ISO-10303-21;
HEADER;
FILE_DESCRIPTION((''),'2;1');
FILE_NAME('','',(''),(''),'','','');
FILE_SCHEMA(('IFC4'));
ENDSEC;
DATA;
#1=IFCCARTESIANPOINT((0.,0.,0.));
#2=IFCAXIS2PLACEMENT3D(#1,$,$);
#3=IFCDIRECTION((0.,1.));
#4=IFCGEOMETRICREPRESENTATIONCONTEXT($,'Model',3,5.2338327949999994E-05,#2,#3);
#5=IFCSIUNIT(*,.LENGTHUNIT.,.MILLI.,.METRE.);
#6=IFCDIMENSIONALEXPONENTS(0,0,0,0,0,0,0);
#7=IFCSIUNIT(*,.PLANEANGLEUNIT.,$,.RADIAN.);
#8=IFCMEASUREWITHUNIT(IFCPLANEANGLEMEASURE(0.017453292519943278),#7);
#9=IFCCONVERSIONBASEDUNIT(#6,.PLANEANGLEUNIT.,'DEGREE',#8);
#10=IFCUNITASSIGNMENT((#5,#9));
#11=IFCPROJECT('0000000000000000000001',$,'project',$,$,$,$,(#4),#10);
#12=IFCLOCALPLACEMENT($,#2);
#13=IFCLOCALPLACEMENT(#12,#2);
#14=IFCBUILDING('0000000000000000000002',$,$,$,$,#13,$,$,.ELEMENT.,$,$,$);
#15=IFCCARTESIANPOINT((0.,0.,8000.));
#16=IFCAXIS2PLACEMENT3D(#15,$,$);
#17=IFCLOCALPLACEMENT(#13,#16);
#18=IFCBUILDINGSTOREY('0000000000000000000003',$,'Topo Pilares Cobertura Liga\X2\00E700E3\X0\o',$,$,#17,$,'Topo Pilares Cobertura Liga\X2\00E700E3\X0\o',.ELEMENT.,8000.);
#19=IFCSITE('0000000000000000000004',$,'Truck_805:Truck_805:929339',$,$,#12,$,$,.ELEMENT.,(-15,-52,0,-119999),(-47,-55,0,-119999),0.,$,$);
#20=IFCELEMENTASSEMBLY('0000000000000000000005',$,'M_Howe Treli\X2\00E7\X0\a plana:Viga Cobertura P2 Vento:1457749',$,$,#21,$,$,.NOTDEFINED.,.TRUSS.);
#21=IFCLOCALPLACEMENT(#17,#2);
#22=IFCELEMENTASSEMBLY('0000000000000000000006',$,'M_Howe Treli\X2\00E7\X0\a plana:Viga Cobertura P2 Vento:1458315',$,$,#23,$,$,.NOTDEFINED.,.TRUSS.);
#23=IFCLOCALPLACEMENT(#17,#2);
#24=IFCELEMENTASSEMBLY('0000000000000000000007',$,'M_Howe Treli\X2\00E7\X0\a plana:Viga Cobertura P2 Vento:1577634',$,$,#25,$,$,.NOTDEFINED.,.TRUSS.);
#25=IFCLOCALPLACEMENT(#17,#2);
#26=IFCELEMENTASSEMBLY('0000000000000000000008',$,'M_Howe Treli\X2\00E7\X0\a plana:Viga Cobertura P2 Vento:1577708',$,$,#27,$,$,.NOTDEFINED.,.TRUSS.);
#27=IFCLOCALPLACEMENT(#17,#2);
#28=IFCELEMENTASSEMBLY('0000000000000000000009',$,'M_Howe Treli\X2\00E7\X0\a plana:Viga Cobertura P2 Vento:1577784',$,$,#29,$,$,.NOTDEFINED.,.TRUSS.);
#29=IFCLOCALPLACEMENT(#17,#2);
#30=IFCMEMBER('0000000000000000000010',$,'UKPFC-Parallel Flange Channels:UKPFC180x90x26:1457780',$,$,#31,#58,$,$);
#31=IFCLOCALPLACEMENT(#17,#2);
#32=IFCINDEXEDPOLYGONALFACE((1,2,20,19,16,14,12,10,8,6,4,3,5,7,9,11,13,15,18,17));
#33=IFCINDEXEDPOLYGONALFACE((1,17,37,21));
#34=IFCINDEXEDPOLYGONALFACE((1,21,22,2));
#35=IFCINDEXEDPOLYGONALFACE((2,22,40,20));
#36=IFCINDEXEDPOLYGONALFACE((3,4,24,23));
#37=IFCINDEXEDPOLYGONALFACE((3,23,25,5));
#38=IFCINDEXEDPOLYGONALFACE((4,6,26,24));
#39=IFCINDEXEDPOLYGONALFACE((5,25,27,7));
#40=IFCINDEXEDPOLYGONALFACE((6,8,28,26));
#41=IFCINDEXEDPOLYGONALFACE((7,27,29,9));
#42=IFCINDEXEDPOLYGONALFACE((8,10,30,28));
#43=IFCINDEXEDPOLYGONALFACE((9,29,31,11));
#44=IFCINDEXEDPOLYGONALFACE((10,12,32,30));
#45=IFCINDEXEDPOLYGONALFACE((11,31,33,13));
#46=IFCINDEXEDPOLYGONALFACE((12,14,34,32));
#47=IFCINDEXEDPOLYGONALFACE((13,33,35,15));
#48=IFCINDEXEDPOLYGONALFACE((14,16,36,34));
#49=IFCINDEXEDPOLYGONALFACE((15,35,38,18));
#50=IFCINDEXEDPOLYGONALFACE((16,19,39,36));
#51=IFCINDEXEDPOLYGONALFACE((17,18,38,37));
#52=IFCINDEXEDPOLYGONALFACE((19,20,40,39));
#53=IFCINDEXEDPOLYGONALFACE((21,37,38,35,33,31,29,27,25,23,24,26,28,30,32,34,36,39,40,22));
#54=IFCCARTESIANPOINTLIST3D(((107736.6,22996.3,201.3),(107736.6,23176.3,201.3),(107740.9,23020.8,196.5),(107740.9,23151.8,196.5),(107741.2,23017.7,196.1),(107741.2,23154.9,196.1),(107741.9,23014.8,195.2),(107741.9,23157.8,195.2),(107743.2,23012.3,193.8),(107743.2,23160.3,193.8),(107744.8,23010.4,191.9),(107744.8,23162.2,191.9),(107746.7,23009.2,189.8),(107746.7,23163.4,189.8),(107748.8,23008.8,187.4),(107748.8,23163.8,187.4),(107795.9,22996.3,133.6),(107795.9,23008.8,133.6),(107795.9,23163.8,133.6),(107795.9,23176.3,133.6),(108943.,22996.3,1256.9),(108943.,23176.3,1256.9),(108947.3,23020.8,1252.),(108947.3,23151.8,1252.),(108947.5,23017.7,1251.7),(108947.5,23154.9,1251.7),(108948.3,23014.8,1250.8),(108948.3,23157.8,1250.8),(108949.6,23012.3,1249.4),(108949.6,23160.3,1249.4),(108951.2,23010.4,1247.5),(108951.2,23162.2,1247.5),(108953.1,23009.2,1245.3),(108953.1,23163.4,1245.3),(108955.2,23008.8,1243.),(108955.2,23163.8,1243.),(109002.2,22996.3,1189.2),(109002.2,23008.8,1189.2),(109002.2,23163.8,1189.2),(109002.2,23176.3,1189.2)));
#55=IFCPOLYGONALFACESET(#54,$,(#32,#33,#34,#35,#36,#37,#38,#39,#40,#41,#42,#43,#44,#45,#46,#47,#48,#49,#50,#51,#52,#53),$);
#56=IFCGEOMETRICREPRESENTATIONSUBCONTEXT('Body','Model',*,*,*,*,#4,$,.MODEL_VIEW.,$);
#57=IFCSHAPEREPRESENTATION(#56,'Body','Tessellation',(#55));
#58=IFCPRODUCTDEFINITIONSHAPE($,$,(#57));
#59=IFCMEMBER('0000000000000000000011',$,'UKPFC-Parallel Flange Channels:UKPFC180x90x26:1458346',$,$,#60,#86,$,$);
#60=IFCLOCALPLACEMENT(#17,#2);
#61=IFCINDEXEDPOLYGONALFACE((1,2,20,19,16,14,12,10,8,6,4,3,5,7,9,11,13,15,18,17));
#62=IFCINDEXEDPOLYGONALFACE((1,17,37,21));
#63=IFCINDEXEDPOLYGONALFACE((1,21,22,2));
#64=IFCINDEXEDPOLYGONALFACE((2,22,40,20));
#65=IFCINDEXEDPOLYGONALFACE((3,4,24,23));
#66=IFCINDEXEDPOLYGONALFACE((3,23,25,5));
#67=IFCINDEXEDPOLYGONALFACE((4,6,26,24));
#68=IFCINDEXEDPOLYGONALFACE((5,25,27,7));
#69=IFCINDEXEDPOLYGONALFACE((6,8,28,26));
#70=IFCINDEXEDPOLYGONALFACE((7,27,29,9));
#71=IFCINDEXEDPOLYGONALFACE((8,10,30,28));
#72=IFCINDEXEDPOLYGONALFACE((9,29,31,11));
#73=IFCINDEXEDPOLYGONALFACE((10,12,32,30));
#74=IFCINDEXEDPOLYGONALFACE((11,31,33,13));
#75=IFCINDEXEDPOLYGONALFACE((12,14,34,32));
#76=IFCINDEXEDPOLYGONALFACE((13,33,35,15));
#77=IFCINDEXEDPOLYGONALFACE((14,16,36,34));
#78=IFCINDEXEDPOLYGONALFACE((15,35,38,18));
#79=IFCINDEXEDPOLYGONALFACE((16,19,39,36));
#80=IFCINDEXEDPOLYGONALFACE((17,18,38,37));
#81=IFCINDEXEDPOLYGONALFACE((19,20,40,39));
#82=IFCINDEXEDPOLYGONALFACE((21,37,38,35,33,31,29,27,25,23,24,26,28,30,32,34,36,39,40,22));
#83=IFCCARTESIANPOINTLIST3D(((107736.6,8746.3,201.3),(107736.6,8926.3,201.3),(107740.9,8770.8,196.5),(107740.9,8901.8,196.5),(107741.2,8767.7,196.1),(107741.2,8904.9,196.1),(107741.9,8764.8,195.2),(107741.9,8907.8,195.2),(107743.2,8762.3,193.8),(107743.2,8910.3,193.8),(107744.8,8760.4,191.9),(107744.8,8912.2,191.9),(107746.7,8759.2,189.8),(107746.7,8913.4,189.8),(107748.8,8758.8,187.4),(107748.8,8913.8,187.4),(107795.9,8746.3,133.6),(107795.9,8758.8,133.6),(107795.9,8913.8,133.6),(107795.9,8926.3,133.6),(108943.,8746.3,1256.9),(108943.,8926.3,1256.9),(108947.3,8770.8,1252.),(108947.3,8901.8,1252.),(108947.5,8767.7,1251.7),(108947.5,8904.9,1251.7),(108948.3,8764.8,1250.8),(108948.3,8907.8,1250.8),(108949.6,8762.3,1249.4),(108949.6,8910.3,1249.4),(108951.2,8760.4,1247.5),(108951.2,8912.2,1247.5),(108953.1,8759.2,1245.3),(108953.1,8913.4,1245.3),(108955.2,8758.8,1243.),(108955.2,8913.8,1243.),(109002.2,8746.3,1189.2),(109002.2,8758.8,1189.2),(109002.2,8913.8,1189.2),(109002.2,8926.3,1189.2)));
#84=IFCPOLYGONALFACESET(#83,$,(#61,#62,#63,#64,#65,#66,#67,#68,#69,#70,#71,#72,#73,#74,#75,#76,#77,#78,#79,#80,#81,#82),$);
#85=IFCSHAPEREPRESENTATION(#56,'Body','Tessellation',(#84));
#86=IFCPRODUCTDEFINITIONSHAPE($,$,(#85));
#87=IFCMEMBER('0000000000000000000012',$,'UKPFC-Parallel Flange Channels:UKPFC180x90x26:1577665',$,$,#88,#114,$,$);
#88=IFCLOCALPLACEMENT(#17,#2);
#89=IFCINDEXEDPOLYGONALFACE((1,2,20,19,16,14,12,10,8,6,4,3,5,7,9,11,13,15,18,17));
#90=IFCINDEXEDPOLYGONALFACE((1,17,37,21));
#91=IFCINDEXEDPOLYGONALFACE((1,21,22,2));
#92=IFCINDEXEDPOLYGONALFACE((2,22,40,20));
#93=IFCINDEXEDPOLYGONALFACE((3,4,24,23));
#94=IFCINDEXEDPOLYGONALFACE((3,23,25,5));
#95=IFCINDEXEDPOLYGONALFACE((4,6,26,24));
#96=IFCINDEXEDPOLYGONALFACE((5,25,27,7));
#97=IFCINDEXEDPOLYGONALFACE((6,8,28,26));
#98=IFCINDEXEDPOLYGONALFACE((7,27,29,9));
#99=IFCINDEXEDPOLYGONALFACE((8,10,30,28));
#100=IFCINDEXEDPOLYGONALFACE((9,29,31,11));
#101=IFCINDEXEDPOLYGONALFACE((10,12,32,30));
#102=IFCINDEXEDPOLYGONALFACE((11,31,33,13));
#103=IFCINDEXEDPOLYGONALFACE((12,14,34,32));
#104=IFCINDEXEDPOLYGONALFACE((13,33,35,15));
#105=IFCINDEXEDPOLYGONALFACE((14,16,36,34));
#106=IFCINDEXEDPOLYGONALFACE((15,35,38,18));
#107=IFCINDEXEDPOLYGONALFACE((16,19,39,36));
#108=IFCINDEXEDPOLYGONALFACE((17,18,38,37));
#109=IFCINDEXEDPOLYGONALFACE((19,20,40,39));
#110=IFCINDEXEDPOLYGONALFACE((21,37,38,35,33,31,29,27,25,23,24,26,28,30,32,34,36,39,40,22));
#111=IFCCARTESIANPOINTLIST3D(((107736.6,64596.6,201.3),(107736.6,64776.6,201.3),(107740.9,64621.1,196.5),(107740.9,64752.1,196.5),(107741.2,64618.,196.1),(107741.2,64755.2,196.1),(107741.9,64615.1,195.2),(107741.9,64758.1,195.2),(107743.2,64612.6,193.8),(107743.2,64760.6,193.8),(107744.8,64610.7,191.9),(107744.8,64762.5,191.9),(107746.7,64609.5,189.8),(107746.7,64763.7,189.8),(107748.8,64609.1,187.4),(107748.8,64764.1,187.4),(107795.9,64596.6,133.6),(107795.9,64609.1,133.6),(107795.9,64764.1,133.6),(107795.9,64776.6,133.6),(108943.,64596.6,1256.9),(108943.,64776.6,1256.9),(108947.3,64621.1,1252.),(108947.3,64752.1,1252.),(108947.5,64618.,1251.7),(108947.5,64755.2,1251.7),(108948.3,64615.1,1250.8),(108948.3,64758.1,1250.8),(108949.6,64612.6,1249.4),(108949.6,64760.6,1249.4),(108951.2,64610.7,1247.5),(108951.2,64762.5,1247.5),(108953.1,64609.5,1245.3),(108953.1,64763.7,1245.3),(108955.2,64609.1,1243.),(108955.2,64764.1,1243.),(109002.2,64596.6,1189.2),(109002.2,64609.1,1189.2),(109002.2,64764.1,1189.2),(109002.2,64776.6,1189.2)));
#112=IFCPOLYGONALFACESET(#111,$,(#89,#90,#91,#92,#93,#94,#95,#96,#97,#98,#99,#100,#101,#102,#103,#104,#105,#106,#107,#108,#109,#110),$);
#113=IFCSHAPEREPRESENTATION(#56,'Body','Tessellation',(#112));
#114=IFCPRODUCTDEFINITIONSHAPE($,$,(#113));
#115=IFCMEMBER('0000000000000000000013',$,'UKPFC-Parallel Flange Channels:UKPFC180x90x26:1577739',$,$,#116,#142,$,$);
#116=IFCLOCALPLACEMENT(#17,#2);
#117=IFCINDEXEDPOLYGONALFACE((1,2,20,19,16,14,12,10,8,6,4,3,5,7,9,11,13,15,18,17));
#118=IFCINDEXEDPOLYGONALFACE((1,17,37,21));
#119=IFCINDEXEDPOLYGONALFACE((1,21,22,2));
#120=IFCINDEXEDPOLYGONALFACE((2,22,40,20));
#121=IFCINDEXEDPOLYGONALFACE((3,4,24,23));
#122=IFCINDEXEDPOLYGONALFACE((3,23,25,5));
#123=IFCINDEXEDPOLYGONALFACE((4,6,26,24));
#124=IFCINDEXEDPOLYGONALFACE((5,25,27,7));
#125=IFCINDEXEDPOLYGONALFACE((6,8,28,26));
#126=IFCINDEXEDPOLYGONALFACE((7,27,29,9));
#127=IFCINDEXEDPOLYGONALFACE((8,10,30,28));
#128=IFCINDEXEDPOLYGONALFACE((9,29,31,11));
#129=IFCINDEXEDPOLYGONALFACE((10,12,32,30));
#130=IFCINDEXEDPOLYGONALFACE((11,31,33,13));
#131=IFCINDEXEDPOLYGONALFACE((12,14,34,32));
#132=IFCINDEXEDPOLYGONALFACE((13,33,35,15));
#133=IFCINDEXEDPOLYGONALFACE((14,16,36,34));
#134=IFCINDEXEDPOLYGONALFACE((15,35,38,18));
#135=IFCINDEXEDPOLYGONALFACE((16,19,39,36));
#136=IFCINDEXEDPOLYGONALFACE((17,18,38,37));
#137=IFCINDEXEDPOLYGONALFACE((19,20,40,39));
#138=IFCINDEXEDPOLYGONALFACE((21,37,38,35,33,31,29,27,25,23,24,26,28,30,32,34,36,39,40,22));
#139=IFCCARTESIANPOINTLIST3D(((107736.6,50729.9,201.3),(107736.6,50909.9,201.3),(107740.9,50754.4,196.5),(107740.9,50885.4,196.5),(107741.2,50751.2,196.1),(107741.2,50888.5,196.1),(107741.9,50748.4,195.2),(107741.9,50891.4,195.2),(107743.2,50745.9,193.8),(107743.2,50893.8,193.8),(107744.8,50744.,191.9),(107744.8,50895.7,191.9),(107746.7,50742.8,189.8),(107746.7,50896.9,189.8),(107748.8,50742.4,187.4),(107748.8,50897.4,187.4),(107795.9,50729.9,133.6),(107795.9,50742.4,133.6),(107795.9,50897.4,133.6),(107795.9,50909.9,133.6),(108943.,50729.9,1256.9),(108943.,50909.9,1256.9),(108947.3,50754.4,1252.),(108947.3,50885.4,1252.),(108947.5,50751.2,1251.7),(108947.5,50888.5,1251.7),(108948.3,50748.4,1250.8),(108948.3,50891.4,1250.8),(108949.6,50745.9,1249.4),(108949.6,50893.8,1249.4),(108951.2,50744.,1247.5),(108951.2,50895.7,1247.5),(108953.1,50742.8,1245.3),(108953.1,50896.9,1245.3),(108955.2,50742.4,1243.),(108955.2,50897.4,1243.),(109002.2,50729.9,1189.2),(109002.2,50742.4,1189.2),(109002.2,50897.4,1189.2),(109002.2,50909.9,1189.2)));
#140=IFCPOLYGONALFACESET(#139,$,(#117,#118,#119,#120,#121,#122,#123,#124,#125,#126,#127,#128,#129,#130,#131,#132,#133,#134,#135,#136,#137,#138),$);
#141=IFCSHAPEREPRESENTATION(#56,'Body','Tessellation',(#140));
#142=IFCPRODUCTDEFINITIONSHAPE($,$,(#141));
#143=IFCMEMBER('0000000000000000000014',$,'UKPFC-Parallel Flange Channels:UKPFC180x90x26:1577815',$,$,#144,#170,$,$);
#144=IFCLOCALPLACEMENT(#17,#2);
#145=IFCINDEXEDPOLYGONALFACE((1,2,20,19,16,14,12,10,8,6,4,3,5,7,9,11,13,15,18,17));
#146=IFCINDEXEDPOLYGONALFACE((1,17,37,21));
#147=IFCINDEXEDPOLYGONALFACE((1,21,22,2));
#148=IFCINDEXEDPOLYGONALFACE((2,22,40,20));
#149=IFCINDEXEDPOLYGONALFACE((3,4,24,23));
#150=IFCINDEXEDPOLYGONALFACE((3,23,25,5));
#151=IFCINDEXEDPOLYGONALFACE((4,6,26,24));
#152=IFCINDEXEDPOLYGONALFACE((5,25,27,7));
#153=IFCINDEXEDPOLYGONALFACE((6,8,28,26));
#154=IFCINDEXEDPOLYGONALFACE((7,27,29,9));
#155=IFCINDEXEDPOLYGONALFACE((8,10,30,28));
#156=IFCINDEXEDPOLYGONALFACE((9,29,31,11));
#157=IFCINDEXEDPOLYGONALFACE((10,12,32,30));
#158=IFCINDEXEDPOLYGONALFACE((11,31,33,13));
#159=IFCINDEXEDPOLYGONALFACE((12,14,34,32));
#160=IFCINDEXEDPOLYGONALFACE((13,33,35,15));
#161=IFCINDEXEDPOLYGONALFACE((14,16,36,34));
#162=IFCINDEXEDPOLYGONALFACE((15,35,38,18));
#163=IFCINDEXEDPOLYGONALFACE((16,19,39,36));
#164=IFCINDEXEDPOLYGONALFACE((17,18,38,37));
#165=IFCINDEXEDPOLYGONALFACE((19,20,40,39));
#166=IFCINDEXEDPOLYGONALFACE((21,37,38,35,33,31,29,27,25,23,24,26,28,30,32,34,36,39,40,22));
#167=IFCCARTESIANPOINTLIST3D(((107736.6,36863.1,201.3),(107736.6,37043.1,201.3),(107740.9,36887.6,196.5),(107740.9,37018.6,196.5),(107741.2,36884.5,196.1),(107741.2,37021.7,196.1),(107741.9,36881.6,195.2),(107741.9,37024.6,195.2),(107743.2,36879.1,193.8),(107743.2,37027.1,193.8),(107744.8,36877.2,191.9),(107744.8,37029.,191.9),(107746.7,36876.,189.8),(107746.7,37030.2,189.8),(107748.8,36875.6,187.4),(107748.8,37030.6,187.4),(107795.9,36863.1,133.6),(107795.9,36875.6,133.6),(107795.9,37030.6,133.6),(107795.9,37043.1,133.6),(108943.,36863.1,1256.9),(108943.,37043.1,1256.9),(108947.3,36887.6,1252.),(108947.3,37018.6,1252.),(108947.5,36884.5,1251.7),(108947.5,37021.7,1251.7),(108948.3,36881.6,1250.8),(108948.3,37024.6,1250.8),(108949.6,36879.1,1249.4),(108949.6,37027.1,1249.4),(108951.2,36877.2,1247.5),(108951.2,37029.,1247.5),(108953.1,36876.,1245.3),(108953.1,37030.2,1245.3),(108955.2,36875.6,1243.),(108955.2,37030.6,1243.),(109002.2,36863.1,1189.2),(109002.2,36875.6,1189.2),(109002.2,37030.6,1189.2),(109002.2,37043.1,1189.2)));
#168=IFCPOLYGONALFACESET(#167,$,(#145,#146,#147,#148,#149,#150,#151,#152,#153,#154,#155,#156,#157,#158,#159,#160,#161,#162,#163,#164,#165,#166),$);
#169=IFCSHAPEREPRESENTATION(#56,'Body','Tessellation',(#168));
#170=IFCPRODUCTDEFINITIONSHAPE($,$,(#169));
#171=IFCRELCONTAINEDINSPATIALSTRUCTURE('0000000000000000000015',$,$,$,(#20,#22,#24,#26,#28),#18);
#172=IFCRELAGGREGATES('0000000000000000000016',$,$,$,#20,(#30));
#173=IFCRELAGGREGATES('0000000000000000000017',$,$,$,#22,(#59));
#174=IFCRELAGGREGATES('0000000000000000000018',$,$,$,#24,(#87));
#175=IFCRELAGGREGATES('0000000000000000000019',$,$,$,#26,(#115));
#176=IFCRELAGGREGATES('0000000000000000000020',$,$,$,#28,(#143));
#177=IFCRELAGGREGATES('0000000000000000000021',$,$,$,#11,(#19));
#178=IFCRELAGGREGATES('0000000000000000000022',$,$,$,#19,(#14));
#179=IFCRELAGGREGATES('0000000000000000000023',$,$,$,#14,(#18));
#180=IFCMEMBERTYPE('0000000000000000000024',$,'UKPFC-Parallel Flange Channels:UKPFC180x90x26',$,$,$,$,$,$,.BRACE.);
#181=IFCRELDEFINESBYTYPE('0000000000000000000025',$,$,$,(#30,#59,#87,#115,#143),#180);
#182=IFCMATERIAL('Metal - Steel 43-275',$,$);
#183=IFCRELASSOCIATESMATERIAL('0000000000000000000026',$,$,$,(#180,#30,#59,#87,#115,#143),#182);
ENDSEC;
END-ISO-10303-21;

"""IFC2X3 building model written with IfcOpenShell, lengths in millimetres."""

from ifc_helpers import new_model, entity, si_unit, converted_unit, direction, frame, frame_2d, origin, place, context, subcontext, project, spatial, polyline, circle_curve, parameter, trimmed, segment, composite_curve, outline, extrude, source, transform, mapped, material, type_object, type_shapes, element, aggregate, save


model = new_model("IFC2X3")

# Units and contexts
model_context = context("Model", 3, precision=5.2338327949999994e-05, world=origin(), true_north=direction((0.0, 1.0)))
body_context = subcontext(model_context, "Body", "Model", "MODEL_VIEW")
ifc_project = project(units=[si_unit("LENGTHUNIT", "METRE", prefix="MILLI"), converted_unit("PLANEANGLEUNIT", "DEGREE", entity("IfcPlaneAngleMeasure", 0.017453292519943278), si_unit("PLANEANGLEUNIT", "RADIAN"), dimensions=[0, 0, 0, 0, 0, 0, 0])], contexts=[model_context])

# Site, building, storey
site_placement = place(None, origin())
site = spatial("IfcSite", under=ifc_project, at=site_placement, Name="Truck_805:Truck_805:929339", CompositionType="ELEMENT", RefLatitude=(-15, -52, 0, -119999), RefLongitude=(-47, -55, 0, -119999), RefElevation=0.0)
building_placement = place(site_placement, origin())
building = spatial("IfcBuilding", under=site, at=building_placement, CompositionType="ELEMENT")
storey_placement = place(building_placement, frame((0.0, 0.0, 8000.0)))
storey = spatial("IfcBuildingStorey", under=building, at=storey_placement, Name="Topo Pilares Cobertura Ligação", LongName="Topo Pilares Cobertura Ligação", CompositionType="ELEMENT", Elevation=8000.0)

# Element assemblies
assembly_1_placement = place(storey_placement, origin())
assembly_1 = element("IfcElementAssembly", 1, at=assembly_1_placement, inside=storey, Name="M_Howe Treliça plana:Viga Cobertura P2 Vento:1457749", AssemblyPlace="NOTDEFINED", PredefinedType="TRUSS")
assembly_2_placement = place(storey_placement, origin())
assembly_2 = element("IfcElementAssembly", 2, at=assembly_2_placement, inside=storey, Name="M_Howe Treliça plana:Viga Cobertura P2 Vento:1458315", AssemblyPlace="NOTDEFINED", PredefinedType="TRUSS")
assembly_3_placement = place(storey_placement, origin())
assembly_3 = element("IfcElementAssembly", 3, at=assembly_3_placement, inside=storey, Name="M_Howe Treliça plana:Viga Cobertura P2 Vento:1577634", AssemblyPlace="NOTDEFINED", PredefinedType="TRUSS")
assembly_4_placement = place(storey_placement, origin())
assembly_4 = element("IfcElementAssembly", 4, at=assembly_4_placement, inside=storey, Name="M_Howe Treliça plana:Viga Cobertura P2 Vento:1577708", AssemblyPlace="NOTDEFINED", PredefinedType="TRUSS")
assembly_5_placement = place(storey_placement, origin())
assembly_5 = element("IfcElementAssembly", 5, at=assembly_5_placement, inside=storey, Name="M_Howe Treliça plana:Viga Cobertura P2 Vento:1577784", AssemblyPlace="NOTDEFINED", PredefinedType="TRUSS")

# Members
ifc_material_1 = material(Name="Metal - Steel 43-275")
member_type_1 = type_object("IfcMemberType", Name="UKPFC-Parallel Flange Channels:UKPFC180x90x26", PredefinedType="BRACE", material=ifc_material_1)
shared_shape_1 = source(origin(), body_context, "Body", "SweptSolid", [
    extrude(outline(composite_curve([segment(polyline([(-90.0, -49.0), (-77.5, -49.0)]), True, "CONTINUOUS"), segment(polyline([(-77.5, -49.0), (-77.5, 22.5)]), True, "CONTINUOUS"), segment(trimmed(circle_curve(frame_2d((-65.5, 22.5), x_axis=(-1.0, 0.0)), 12.0), [parameter(270.0)], [parameter(0.0)], True, "PARAMETER"), False, "CONTINUOUS"), segment(polyline([(-65.5, 34.5), (65.5, 34.5)]), True, "CONTINUOUS"), segment(trimmed(circle_curve(frame_2d((65.5, 22.5), x_axis=(0.0, 1.0)), 12.0), [parameter(270.0)], [parameter(0.0)], True, "PARAMETER"), False, "CONTINUOUS"), segment(polyline([(77.5, 22.5), (77.5, -49.0)]), True, "CONTINUOUS"), segment(polyline([(77.5, -49.0), (90.0, -49.0)]), True, "CONTINUOUS"), segment(polyline([(90.0, -49.0), (90.0, 41.0)]), True, "CONTINUOUS"), segment(polyline([(90.0, 41.0), (-90.0, 41.0)]), True, "CONTINUOUS"), segment(polyline([(-90.0, 41.0), (-90.0, -49.0)]), True, "CONTINUOUS")], self_intersect=False)), frame((-785.0, -9.3, 0.0), z_axis=(1.0, 0.0, 0.0), x_axis=(0.0, 0.0, -1.0)), (0.0, 0.0, 1.0), 1603.0),
])
type_shapes(member_type_1, [shared_shape_1])
member_1_placement = place(assembly_1_placement, frame((108348.2, 23086.3, 694.4), z_axis=(0.0, -1.0, 0.0), x_axis=(0.752577, 0.0, 0.658505)))
member_1 = element("IfcMember", 6, at=member_1_placement, type_object=member_type_1, material=ifc_material_1, Name="UKPFC-Parallel Flange Channels:UKPFC180x90x26:1457780", context=body_context, shape_type="MappedRepresentation", body=[
    mapped(shared_shape_1, transform((0.0, 0.0, 0.0), scale=1.0)),
])
aggregate(assembly_1, [member_1])
member_2_placement = place(assembly_2_placement, frame((108348.2, 8836.3, 694.4), z_axis=(0.0, -1.0, 0.0), x_axis=(0.752577, 0.0, 0.658505)))
member_2 = element("IfcMember", 7, at=member_2_placement, type_object=member_type_1, material=ifc_material_1, Name="UKPFC-Parallel Flange Channels:UKPFC180x90x26:1458346", context=body_context, shape_type="MappedRepresentation", body=[
    mapped(shared_shape_1, transform((0.0, 0.0, 0.0), scale=1.0)),
])
aggregate(assembly_2, [member_2])
member_3_placement = place(assembly_3_placement, frame((108348.2, 64686.6, 694.4), z_axis=(0.0, -1.0, 0.0), x_axis=(0.752577, 0.0, 0.658505)))
member_3 = element("IfcMember", 8, at=member_3_placement, type_object=member_type_1, material=ifc_material_1, Name="UKPFC-Parallel Flange Channels:UKPFC180x90x26:1577665", context=body_context, shape_type="MappedRepresentation", body=[
    mapped(shared_shape_1, transform((0.0, 0.0, 0.0), scale=1.0)),
])
aggregate(assembly_3, [member_3])
member_4_placement = place(assembly_4_placement, frame((108348.2, 50819.9, 694.4), z_axis=(0.0, -1.0, 0.0), x_axis=(0.752577, 0.0, 0.658505)))
member_4 = element("IfcMember", 9, at=member_4_placement, type_object=member_type_1, material=ifc_material_1, Name="UKPFC-Parallel Flange Channels:UKPFC180x90x26:1577739", context=body_context, shape_type="MappedRepresentation", body=[
    mapped(shared_shape_1, transform((0.0, 0.0, 0.0), scale=1.0)),
])
aggregate(assembly_4, [member_4])
member_5_placement = place(assembly_5_placement, frame((108348.2, 36953.1, 694.4), z_axis=(0.0, -1.0, 0.0), x_axis=(0.752577, 0.0, 0.658505)))
member_5 = element("IfcMember", 10, at=member_5_placement, type_object=member_type_1, material=ifc_material_1, Name="UKPFC-Parallel Flange Channels:UKPFC180x90x26:1577815", context=body_context, shape_type="MappedRepresentation", body=[
    mapped(shared_shape_1, transform((0.0, 0.0, 0.0), scale=1.0)),
])
aggregate(assembly_5, [member_5])

save(model, "model.ifc")
